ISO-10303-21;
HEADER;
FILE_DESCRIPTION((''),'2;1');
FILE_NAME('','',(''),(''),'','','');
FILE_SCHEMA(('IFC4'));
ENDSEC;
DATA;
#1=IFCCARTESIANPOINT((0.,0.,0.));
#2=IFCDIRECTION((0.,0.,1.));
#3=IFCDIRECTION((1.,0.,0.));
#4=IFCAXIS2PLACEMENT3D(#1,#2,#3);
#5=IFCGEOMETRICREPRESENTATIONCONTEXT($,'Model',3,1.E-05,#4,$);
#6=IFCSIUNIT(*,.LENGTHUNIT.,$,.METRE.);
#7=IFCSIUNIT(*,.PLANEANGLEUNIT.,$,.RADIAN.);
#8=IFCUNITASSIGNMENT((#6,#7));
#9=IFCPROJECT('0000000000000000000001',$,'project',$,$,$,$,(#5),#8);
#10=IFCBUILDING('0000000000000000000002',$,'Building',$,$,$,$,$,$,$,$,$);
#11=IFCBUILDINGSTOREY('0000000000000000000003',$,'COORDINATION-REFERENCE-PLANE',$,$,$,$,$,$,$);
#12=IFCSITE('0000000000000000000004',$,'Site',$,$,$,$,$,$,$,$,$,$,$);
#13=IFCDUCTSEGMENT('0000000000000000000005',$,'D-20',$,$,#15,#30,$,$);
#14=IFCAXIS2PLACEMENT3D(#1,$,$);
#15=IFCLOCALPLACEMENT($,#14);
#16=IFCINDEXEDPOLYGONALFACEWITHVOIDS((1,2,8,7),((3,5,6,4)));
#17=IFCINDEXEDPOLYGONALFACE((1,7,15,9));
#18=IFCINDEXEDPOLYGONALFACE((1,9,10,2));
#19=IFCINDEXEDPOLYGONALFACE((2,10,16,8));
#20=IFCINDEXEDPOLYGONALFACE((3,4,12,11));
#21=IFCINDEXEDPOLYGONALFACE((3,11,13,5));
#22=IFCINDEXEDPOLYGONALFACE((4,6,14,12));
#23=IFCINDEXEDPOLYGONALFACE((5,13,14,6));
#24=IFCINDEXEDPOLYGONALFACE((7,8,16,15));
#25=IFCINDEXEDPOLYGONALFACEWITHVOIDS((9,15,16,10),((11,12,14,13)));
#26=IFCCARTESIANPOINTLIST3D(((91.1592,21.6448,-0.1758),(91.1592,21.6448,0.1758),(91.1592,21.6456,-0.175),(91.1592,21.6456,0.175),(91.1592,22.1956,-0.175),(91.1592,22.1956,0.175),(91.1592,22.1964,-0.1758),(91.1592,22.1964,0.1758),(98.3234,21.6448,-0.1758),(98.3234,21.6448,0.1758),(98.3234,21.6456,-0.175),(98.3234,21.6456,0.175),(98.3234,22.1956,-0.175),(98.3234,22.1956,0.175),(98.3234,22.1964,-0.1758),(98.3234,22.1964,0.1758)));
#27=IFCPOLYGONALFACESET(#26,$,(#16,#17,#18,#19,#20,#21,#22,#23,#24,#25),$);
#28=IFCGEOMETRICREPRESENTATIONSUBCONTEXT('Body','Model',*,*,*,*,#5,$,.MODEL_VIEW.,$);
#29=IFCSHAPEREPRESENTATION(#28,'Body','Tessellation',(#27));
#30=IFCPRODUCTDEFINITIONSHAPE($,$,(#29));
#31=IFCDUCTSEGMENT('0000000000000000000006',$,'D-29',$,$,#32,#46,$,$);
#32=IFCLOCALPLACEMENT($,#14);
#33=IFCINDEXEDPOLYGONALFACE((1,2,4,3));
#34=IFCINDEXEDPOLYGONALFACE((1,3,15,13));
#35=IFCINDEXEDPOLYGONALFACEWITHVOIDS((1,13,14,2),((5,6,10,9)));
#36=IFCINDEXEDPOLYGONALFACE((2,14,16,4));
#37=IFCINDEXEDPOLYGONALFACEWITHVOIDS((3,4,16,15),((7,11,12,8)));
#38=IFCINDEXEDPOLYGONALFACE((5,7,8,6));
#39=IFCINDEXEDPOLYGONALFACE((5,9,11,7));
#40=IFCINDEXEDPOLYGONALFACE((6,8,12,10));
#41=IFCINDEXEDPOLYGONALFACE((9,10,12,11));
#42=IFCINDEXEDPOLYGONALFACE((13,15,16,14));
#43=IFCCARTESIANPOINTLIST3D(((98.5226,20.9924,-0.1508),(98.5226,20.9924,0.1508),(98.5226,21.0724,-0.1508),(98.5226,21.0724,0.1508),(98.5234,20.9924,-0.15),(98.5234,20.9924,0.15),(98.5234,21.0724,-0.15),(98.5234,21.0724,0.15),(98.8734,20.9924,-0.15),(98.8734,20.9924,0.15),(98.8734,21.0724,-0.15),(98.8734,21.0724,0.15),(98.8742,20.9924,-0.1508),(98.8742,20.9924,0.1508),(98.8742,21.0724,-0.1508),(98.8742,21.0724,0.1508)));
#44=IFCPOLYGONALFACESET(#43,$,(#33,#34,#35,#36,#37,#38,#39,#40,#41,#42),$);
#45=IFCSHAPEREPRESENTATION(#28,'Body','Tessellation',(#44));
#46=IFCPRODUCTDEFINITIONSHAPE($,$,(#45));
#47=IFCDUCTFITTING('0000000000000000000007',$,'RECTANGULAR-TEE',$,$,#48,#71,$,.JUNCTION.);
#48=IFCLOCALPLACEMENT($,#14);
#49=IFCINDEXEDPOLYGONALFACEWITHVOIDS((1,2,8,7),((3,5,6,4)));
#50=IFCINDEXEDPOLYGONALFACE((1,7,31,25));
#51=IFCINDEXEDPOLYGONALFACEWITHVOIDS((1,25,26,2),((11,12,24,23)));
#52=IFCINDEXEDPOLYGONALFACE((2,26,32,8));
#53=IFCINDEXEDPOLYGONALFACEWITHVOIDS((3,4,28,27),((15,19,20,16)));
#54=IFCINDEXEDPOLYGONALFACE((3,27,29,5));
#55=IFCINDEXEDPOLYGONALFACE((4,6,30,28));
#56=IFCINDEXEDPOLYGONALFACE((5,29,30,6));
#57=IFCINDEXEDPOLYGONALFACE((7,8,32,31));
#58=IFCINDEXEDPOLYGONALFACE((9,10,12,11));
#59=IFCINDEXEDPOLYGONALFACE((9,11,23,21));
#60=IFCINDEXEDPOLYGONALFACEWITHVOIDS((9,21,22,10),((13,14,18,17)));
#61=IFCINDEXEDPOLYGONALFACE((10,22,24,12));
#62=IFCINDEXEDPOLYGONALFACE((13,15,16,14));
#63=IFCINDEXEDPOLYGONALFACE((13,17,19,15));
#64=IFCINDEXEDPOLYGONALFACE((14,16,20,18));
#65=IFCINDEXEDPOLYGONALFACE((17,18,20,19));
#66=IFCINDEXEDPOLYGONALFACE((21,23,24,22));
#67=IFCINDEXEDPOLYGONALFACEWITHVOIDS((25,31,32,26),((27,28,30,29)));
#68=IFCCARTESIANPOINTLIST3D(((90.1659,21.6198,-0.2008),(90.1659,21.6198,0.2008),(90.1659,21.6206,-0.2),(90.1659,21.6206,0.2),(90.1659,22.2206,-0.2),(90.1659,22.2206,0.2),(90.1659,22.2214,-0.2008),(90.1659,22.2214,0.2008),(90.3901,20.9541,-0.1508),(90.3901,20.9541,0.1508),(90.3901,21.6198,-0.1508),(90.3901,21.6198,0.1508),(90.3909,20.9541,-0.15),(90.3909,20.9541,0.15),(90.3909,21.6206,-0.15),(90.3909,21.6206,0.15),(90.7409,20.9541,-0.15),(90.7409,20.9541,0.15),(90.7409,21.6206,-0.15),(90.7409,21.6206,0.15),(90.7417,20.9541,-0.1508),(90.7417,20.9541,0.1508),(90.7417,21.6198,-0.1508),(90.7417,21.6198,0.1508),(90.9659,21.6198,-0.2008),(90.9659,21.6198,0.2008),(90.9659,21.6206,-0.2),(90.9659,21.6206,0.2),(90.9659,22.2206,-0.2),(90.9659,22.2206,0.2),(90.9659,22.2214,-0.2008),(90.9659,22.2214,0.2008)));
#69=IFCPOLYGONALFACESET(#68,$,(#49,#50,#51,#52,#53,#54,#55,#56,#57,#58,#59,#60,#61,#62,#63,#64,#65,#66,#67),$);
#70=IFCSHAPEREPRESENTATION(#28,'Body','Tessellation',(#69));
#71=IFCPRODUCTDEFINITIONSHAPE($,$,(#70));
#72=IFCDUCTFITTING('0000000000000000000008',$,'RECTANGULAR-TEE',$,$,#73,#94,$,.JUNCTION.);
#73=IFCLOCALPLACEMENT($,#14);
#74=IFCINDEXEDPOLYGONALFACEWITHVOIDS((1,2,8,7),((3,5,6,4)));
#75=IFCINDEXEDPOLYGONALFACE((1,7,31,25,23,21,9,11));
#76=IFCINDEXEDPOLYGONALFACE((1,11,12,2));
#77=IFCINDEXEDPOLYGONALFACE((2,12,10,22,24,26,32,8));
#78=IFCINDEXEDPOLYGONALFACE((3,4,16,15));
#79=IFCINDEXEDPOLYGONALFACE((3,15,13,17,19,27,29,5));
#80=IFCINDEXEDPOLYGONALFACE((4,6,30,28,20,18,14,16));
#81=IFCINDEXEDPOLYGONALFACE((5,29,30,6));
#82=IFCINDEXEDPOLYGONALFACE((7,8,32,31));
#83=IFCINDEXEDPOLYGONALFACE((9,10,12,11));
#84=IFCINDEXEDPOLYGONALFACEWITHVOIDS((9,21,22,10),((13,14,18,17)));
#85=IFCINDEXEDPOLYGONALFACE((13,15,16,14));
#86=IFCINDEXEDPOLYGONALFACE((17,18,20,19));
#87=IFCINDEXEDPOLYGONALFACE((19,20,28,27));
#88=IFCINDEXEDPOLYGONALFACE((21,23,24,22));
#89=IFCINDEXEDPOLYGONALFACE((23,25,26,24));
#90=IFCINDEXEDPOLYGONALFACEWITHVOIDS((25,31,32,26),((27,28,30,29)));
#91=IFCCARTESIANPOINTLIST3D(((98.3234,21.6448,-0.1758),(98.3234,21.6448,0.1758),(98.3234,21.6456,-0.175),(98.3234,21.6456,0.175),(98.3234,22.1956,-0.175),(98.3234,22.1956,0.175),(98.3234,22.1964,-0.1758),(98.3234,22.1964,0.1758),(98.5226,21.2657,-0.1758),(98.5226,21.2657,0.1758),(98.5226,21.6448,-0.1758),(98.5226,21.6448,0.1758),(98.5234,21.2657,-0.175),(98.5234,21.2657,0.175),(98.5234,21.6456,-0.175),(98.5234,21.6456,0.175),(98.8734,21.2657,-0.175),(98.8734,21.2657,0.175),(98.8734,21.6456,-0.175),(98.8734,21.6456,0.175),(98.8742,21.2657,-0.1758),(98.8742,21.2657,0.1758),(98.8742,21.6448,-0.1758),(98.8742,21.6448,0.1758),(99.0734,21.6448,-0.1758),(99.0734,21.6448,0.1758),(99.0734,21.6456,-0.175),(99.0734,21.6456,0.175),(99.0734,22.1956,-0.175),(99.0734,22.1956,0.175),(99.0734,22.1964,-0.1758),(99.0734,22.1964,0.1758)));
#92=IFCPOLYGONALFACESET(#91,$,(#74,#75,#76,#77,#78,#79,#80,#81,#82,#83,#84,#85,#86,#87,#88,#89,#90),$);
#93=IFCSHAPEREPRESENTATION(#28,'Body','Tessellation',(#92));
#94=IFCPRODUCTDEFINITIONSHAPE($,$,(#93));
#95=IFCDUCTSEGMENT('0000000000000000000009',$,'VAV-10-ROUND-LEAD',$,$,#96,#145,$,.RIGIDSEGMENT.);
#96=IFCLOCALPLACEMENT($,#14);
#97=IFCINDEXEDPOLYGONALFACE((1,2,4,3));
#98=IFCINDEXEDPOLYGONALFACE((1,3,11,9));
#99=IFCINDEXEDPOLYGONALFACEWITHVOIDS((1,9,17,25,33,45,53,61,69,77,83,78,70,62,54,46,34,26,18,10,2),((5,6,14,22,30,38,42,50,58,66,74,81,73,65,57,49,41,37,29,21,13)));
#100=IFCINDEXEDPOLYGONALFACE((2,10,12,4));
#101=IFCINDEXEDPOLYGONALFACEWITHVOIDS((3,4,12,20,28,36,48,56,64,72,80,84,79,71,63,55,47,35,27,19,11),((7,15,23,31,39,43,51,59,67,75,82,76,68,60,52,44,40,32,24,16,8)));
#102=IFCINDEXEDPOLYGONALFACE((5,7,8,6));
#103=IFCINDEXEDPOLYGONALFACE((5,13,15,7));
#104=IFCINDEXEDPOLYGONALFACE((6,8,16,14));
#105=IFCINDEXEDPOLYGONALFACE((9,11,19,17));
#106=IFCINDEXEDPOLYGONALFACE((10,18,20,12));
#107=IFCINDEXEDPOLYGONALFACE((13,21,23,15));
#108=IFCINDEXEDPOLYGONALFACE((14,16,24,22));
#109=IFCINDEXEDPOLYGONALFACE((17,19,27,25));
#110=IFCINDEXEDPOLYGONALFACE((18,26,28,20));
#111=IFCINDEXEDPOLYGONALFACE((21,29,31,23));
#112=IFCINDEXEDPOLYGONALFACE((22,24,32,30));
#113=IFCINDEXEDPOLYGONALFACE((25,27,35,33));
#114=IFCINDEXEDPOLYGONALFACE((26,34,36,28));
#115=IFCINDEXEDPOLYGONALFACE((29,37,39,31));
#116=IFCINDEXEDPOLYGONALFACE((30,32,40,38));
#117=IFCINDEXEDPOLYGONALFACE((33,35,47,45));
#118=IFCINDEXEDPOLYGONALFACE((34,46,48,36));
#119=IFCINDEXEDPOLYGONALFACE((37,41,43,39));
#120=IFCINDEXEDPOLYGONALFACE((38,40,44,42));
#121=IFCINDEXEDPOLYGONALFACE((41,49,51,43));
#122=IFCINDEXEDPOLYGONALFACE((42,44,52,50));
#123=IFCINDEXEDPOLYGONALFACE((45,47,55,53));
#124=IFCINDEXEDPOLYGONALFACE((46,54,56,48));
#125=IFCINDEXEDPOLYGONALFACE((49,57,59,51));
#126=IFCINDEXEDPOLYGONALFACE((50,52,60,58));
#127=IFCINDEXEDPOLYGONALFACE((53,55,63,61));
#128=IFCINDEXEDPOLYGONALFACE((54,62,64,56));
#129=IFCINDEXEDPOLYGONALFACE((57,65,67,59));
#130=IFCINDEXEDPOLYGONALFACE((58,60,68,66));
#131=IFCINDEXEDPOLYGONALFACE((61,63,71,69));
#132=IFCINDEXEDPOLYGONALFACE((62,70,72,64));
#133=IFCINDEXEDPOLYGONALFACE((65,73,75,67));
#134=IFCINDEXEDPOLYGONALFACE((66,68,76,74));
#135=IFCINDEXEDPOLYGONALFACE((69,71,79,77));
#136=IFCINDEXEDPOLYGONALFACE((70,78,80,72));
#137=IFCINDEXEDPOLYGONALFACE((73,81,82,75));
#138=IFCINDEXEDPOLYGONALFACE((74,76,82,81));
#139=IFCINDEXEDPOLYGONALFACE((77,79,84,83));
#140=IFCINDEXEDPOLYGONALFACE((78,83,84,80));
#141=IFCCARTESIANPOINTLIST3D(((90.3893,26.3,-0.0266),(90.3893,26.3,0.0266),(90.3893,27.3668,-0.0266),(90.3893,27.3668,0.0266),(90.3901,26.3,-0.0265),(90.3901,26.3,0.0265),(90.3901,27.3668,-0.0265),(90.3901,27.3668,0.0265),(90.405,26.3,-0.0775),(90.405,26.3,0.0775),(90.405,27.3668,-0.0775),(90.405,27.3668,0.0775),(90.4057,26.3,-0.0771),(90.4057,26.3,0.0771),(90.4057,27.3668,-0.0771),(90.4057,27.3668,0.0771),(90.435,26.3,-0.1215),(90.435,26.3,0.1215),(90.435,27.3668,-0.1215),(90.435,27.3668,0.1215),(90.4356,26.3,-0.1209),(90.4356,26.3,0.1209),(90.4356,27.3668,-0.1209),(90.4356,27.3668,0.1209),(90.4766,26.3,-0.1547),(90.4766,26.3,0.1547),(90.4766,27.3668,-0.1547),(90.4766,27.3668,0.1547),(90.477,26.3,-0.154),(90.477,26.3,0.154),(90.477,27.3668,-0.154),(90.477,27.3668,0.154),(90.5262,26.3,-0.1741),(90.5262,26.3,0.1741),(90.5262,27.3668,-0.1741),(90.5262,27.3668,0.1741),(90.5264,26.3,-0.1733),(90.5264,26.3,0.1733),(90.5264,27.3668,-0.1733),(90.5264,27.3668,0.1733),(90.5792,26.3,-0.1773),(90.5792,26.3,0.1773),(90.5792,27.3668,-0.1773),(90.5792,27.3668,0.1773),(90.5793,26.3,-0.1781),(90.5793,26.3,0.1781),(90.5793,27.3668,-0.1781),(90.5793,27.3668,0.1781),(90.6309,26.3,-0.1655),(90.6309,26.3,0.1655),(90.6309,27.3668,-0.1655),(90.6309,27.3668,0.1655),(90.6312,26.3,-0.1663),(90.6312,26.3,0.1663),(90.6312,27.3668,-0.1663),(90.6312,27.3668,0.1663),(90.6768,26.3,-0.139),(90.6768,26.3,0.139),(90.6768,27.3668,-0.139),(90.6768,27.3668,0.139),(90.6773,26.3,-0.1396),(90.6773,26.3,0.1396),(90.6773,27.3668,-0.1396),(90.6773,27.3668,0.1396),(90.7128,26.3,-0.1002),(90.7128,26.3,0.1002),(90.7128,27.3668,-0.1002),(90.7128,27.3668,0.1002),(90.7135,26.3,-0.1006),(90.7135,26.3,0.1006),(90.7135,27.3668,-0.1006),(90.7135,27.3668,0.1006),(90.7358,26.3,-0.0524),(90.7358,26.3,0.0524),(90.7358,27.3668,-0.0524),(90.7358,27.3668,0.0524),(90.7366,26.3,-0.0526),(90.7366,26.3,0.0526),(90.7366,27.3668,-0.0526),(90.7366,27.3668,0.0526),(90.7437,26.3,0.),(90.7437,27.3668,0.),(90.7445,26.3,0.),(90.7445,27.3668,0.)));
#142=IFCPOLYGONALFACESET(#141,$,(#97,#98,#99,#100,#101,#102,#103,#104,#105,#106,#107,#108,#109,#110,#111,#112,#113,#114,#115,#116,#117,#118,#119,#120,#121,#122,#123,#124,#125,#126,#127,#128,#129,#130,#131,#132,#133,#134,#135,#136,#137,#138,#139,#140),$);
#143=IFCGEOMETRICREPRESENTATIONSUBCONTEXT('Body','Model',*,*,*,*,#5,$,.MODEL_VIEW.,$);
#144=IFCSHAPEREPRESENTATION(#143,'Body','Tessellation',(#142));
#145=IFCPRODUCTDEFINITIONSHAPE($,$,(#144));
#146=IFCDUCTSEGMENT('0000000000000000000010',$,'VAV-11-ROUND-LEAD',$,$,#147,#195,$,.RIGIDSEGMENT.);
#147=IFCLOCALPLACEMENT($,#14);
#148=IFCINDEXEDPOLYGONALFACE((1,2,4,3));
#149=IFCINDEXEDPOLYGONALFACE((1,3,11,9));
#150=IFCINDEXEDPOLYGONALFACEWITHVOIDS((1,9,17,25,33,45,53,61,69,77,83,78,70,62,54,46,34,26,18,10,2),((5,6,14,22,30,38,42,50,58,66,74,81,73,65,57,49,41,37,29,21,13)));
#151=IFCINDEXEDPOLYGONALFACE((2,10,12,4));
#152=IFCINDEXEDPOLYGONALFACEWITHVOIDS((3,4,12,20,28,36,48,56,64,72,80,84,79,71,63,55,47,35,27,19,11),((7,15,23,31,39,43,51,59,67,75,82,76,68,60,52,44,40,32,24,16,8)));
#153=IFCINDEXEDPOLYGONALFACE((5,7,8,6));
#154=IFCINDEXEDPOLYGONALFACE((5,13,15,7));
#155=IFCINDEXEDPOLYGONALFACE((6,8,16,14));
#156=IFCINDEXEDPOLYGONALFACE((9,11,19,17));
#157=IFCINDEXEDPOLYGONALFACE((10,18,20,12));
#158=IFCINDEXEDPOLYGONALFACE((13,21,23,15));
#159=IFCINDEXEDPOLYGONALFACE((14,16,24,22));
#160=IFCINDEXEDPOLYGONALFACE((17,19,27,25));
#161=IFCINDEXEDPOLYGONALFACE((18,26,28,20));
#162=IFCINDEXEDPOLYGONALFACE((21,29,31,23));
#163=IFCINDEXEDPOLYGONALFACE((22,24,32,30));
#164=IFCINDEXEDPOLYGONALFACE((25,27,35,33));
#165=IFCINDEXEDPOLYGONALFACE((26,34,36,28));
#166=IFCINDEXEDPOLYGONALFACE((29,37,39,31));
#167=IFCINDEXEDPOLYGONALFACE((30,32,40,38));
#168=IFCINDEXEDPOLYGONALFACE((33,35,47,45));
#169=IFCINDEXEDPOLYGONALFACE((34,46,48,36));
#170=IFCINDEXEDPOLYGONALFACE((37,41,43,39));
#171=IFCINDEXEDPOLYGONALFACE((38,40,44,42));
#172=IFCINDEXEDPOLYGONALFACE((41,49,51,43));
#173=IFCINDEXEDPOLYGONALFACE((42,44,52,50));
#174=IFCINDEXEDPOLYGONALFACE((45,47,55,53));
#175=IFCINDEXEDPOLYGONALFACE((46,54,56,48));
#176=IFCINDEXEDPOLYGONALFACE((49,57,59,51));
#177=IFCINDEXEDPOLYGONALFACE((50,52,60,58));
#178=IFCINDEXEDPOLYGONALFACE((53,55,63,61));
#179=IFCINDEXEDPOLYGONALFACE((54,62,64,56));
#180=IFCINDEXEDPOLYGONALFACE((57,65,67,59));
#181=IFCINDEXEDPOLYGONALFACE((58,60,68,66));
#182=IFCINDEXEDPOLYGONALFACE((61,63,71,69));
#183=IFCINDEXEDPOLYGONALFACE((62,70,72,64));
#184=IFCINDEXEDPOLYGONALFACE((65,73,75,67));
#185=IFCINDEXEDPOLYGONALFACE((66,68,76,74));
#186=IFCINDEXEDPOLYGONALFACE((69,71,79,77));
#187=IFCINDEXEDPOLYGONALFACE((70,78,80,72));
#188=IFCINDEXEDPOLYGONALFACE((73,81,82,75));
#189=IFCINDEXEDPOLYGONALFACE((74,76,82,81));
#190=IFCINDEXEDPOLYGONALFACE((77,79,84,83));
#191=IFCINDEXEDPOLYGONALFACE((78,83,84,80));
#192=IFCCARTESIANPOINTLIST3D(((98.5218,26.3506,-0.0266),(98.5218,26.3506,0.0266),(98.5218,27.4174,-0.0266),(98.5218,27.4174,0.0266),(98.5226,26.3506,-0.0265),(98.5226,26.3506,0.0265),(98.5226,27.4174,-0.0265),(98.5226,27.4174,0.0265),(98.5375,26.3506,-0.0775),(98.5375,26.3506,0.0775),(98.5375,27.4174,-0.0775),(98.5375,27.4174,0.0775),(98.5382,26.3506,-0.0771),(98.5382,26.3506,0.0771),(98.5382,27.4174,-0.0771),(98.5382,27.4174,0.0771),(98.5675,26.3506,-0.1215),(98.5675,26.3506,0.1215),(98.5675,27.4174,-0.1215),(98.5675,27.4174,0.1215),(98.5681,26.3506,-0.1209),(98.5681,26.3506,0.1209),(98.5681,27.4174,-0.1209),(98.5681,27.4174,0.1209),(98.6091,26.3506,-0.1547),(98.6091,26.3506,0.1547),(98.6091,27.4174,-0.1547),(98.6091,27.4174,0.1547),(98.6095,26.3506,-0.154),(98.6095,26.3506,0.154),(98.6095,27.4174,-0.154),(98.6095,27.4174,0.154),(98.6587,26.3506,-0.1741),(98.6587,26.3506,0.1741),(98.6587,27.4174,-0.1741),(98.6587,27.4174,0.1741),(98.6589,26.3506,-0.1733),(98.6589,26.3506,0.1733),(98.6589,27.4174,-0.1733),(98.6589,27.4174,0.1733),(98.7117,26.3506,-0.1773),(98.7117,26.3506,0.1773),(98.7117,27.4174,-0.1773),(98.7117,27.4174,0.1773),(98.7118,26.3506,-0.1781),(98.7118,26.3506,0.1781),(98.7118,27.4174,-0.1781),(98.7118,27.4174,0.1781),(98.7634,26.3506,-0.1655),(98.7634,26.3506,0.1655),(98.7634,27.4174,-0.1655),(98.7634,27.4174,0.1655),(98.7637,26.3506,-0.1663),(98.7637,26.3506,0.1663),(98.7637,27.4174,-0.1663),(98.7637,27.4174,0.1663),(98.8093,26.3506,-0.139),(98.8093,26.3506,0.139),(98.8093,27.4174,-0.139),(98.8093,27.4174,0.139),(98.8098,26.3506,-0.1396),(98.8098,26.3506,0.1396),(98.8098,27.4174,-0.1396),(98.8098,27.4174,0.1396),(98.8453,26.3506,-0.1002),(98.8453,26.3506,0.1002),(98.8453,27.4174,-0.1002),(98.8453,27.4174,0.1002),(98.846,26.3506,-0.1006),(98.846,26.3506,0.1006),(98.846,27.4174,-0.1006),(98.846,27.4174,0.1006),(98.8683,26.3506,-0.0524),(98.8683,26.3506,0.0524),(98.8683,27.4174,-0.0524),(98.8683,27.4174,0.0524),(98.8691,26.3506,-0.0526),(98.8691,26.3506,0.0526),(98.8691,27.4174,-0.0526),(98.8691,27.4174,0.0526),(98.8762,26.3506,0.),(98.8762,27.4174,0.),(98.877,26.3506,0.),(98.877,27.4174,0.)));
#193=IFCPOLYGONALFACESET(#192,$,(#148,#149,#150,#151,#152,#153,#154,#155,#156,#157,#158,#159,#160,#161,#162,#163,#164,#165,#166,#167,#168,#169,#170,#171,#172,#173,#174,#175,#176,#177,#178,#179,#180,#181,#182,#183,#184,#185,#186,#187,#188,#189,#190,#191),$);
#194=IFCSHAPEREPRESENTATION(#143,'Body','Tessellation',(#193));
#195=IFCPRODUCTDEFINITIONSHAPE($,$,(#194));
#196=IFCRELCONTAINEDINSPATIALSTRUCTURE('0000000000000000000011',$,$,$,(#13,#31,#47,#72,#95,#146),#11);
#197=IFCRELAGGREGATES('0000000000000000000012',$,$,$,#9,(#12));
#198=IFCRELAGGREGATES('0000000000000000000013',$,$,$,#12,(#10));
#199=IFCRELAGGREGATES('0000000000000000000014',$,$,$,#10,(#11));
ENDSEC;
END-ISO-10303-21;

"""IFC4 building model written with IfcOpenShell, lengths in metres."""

from ifc_helpers import new_model, si_unit, frame, origin, origin_with_axes, place, context, subcontext, project, spatial, rectangle, hollow_rectangle, hollow_circle, extrude, boolean, element, save


model = new_model("IFC4")

# Units and contexts
model_context = context("Model", 3, precision=1e-05, world=origin_with_axes())
body_context_1 = subcontext(model_context, "Body", "Model", "MODEL_VIEW")
body_context_2 = subcontext(model_context, "Body", "Model", "MODEL_VIEW")
ifc_project = project(units=[si_unit("LENGTHUNIT", "METRE"), si_unit("PLANEANGLEUNIT", "RADIAN")], contexts=[model_context])

# Site, building, storey
site = spatial("IfcSite", under=ifc_project, Name="Site")
building = spatial("IfcBuilding", under=site, Name="Building")
storey = spatial("IfcBuildingStorey", under=building, Name="COORDINATION-REFERENCE-PLANE")

# Duct segments
duct_segment_1_placement = place(None, frame((91.1592, 21.9206, 0.0), z_axis=(1.0, 0.0, 0.0), x_axis=(0.0, 1.0, 0.0)))
element("IfcDuctSegment", 1, at=duct_segment_1_placement, inside=storey, Name="D-20", context=body_context_1, shape_type="SweptSolid", body=[
    extrude(hollow_rectangle(XDim=0.5516, YDim=0.3516, WallThickness=0.0008), origin(), (0.0, 0.0, 1.0), 7.1642),
])
duct_segment_2_placement = place(None, frame((98.6984, 20.9924, 0.0), z_axis=(0.0, 1.0, 0.0), x_axis=(1.0, 0.0, 0.0)))
element("IfcDuctSegment", 2, at=duct_segment_2_placement, inside=storey, Name="D-29", context=body_context_1, shape_type="SweptSolid", body=[
    extrude(hollow_rectangle(XDim=0.3516, YDim=0.3016, WallThickness=0.0008), origin(), (0.0, 0.0, 1.0), 0.08),
])

# Duct fittings
duct_fitting_1_placement = place(None, frame((90.5659, 21.9206, 0.0), z_axis=(1.0, 0.0, 0.0), x_axis=(0.0, -1.0, 0.0)))
solid_1 = boolean("UNION", extrude(rectangle(XDim=0.6, YDim=0.4), frame((0.0, 0.0, -0.4), z_axis=(0.0, 0.0, 1.0), x_axis=(1.0, 0.0, 0.0)), (0.0, 0.0, 1.0), 0.8), extrude(rectangle(XDim=0.35, YDim=0.3), frame((0.0, 0.0, 0.0), z_axis=(1.0, 0.0, 0.0), x_axis=(0.0, 0.0, -1.0)), (0.0, 0.0, 1.0), 0.9665))
element("IfcDuctFitting", 3, at=duct_fitting_1_placement, inside=storey, Name="RECTANGULAR-TEE", PredefinedType="JUNCTION", context=body_context_1, shape_type="CSG", body=[
    boolean("DIFFERENCE", boolean("UNION", extrude(rectangle(XDim=0.6016, YDim=0.4016), frame((0.0, 0.0, -0.4), z_axis=(0.0, 0.0, 1.0), x_axis=(1.0, 0.0, 0.0)), (0.0, 0.0, 1.0), 0.8), extrude(rectangle(XDim=0.3516, YDim=0.3016), frame((0.0, 0.0, 0.0), z_axis=(1.0, 0.0, 0.0), x_axis=(0.0, 0.0, -1.0)), (0.0, 0.0, 1.0), 0.9665)), solid_1),
])
duct_fitting_2_placement = place(None, frame((98.6984, 21.9206, 0.0), z_axis=(1.0, 0.0, 0.0), x_axis=(0.0, -1.0, 0.0)))
solid_2 = boolean("UNION", extrude(rectangle(XDim=0.55, YDim=0.35), frame((0.0, 0.0, -0.375), z_axis=(0.0, 0.0, 1.0), x_axis=(1.0, 0.0, 0.0)), (0.0, 0.0, 1.0), 0.75), extrude(rectangle(XDim=0.35, YDim=0.35), frame((0.0, 0.0, 0.0), z_axis=(1.0, 0.0, 0.0), x_axis=(0.0, 0.0, -1.0)), (0.0, 0.0, 1.0), 0.6549))
element("IfcDuctFitting", 4, at=duct_fitting_2_placement, inside=storey, Name="RECTANGULAR-TEE", PredefinedType="JUNCTION", context=body_context_1, shape_type="CSG", body=[
    boolean("DIFFERENCE", boolean("UNION", extrude(rectangle(XDim=0.5516, YDim=0.3516), frame((0.0, 0.0, -0.375), z_axis=(0.0, 0.0, 1.0), x_axis=(1.0, 0.0, 0.0)), (0.0, 0.0, 1.0), 0.75), extrude(rectangle(XDim=0.3516, YDim=0.3516), frame((0.0, 0.0, 0.0), z_axis=(1.0, 0.0, 0.0), x_axis=(0.0, 0.0, -1.0)), (0.0, 0.0, 1.0), 0.6549)), solid_2),
])

# Duct segments
for number, where, z_axis, x_axis, name in (
    (5, (90.5659, 27.3668, 0.0), (0.0, -1.0, 0.0), (1.0, 0.0, 0.0), "VAV-10-ROUND-LEAD"),
    (6, (98.6984, 27.4174, 0.0), (0.0, -1.0, 0.0), (1.0, 0.0, 0.0), "VAV-11-ROUND-LEAD"),
):
    element("IfcDuctSegment", number, at=place(None, frame(where, z_axis=z_axis, x_axis=x_axis)), inside=storey, Name=name, PredefinedType="RIGIDSEGMENT", context=body_context_2, shape_type="SweptSolid", body=[
        extrude(hollow_circle(Radius=0.1786, WallThickness=0.0008), origin(), (0.0, 0.0, 1.0), 1.0668),
    ])

save(model, "model.ifc")
